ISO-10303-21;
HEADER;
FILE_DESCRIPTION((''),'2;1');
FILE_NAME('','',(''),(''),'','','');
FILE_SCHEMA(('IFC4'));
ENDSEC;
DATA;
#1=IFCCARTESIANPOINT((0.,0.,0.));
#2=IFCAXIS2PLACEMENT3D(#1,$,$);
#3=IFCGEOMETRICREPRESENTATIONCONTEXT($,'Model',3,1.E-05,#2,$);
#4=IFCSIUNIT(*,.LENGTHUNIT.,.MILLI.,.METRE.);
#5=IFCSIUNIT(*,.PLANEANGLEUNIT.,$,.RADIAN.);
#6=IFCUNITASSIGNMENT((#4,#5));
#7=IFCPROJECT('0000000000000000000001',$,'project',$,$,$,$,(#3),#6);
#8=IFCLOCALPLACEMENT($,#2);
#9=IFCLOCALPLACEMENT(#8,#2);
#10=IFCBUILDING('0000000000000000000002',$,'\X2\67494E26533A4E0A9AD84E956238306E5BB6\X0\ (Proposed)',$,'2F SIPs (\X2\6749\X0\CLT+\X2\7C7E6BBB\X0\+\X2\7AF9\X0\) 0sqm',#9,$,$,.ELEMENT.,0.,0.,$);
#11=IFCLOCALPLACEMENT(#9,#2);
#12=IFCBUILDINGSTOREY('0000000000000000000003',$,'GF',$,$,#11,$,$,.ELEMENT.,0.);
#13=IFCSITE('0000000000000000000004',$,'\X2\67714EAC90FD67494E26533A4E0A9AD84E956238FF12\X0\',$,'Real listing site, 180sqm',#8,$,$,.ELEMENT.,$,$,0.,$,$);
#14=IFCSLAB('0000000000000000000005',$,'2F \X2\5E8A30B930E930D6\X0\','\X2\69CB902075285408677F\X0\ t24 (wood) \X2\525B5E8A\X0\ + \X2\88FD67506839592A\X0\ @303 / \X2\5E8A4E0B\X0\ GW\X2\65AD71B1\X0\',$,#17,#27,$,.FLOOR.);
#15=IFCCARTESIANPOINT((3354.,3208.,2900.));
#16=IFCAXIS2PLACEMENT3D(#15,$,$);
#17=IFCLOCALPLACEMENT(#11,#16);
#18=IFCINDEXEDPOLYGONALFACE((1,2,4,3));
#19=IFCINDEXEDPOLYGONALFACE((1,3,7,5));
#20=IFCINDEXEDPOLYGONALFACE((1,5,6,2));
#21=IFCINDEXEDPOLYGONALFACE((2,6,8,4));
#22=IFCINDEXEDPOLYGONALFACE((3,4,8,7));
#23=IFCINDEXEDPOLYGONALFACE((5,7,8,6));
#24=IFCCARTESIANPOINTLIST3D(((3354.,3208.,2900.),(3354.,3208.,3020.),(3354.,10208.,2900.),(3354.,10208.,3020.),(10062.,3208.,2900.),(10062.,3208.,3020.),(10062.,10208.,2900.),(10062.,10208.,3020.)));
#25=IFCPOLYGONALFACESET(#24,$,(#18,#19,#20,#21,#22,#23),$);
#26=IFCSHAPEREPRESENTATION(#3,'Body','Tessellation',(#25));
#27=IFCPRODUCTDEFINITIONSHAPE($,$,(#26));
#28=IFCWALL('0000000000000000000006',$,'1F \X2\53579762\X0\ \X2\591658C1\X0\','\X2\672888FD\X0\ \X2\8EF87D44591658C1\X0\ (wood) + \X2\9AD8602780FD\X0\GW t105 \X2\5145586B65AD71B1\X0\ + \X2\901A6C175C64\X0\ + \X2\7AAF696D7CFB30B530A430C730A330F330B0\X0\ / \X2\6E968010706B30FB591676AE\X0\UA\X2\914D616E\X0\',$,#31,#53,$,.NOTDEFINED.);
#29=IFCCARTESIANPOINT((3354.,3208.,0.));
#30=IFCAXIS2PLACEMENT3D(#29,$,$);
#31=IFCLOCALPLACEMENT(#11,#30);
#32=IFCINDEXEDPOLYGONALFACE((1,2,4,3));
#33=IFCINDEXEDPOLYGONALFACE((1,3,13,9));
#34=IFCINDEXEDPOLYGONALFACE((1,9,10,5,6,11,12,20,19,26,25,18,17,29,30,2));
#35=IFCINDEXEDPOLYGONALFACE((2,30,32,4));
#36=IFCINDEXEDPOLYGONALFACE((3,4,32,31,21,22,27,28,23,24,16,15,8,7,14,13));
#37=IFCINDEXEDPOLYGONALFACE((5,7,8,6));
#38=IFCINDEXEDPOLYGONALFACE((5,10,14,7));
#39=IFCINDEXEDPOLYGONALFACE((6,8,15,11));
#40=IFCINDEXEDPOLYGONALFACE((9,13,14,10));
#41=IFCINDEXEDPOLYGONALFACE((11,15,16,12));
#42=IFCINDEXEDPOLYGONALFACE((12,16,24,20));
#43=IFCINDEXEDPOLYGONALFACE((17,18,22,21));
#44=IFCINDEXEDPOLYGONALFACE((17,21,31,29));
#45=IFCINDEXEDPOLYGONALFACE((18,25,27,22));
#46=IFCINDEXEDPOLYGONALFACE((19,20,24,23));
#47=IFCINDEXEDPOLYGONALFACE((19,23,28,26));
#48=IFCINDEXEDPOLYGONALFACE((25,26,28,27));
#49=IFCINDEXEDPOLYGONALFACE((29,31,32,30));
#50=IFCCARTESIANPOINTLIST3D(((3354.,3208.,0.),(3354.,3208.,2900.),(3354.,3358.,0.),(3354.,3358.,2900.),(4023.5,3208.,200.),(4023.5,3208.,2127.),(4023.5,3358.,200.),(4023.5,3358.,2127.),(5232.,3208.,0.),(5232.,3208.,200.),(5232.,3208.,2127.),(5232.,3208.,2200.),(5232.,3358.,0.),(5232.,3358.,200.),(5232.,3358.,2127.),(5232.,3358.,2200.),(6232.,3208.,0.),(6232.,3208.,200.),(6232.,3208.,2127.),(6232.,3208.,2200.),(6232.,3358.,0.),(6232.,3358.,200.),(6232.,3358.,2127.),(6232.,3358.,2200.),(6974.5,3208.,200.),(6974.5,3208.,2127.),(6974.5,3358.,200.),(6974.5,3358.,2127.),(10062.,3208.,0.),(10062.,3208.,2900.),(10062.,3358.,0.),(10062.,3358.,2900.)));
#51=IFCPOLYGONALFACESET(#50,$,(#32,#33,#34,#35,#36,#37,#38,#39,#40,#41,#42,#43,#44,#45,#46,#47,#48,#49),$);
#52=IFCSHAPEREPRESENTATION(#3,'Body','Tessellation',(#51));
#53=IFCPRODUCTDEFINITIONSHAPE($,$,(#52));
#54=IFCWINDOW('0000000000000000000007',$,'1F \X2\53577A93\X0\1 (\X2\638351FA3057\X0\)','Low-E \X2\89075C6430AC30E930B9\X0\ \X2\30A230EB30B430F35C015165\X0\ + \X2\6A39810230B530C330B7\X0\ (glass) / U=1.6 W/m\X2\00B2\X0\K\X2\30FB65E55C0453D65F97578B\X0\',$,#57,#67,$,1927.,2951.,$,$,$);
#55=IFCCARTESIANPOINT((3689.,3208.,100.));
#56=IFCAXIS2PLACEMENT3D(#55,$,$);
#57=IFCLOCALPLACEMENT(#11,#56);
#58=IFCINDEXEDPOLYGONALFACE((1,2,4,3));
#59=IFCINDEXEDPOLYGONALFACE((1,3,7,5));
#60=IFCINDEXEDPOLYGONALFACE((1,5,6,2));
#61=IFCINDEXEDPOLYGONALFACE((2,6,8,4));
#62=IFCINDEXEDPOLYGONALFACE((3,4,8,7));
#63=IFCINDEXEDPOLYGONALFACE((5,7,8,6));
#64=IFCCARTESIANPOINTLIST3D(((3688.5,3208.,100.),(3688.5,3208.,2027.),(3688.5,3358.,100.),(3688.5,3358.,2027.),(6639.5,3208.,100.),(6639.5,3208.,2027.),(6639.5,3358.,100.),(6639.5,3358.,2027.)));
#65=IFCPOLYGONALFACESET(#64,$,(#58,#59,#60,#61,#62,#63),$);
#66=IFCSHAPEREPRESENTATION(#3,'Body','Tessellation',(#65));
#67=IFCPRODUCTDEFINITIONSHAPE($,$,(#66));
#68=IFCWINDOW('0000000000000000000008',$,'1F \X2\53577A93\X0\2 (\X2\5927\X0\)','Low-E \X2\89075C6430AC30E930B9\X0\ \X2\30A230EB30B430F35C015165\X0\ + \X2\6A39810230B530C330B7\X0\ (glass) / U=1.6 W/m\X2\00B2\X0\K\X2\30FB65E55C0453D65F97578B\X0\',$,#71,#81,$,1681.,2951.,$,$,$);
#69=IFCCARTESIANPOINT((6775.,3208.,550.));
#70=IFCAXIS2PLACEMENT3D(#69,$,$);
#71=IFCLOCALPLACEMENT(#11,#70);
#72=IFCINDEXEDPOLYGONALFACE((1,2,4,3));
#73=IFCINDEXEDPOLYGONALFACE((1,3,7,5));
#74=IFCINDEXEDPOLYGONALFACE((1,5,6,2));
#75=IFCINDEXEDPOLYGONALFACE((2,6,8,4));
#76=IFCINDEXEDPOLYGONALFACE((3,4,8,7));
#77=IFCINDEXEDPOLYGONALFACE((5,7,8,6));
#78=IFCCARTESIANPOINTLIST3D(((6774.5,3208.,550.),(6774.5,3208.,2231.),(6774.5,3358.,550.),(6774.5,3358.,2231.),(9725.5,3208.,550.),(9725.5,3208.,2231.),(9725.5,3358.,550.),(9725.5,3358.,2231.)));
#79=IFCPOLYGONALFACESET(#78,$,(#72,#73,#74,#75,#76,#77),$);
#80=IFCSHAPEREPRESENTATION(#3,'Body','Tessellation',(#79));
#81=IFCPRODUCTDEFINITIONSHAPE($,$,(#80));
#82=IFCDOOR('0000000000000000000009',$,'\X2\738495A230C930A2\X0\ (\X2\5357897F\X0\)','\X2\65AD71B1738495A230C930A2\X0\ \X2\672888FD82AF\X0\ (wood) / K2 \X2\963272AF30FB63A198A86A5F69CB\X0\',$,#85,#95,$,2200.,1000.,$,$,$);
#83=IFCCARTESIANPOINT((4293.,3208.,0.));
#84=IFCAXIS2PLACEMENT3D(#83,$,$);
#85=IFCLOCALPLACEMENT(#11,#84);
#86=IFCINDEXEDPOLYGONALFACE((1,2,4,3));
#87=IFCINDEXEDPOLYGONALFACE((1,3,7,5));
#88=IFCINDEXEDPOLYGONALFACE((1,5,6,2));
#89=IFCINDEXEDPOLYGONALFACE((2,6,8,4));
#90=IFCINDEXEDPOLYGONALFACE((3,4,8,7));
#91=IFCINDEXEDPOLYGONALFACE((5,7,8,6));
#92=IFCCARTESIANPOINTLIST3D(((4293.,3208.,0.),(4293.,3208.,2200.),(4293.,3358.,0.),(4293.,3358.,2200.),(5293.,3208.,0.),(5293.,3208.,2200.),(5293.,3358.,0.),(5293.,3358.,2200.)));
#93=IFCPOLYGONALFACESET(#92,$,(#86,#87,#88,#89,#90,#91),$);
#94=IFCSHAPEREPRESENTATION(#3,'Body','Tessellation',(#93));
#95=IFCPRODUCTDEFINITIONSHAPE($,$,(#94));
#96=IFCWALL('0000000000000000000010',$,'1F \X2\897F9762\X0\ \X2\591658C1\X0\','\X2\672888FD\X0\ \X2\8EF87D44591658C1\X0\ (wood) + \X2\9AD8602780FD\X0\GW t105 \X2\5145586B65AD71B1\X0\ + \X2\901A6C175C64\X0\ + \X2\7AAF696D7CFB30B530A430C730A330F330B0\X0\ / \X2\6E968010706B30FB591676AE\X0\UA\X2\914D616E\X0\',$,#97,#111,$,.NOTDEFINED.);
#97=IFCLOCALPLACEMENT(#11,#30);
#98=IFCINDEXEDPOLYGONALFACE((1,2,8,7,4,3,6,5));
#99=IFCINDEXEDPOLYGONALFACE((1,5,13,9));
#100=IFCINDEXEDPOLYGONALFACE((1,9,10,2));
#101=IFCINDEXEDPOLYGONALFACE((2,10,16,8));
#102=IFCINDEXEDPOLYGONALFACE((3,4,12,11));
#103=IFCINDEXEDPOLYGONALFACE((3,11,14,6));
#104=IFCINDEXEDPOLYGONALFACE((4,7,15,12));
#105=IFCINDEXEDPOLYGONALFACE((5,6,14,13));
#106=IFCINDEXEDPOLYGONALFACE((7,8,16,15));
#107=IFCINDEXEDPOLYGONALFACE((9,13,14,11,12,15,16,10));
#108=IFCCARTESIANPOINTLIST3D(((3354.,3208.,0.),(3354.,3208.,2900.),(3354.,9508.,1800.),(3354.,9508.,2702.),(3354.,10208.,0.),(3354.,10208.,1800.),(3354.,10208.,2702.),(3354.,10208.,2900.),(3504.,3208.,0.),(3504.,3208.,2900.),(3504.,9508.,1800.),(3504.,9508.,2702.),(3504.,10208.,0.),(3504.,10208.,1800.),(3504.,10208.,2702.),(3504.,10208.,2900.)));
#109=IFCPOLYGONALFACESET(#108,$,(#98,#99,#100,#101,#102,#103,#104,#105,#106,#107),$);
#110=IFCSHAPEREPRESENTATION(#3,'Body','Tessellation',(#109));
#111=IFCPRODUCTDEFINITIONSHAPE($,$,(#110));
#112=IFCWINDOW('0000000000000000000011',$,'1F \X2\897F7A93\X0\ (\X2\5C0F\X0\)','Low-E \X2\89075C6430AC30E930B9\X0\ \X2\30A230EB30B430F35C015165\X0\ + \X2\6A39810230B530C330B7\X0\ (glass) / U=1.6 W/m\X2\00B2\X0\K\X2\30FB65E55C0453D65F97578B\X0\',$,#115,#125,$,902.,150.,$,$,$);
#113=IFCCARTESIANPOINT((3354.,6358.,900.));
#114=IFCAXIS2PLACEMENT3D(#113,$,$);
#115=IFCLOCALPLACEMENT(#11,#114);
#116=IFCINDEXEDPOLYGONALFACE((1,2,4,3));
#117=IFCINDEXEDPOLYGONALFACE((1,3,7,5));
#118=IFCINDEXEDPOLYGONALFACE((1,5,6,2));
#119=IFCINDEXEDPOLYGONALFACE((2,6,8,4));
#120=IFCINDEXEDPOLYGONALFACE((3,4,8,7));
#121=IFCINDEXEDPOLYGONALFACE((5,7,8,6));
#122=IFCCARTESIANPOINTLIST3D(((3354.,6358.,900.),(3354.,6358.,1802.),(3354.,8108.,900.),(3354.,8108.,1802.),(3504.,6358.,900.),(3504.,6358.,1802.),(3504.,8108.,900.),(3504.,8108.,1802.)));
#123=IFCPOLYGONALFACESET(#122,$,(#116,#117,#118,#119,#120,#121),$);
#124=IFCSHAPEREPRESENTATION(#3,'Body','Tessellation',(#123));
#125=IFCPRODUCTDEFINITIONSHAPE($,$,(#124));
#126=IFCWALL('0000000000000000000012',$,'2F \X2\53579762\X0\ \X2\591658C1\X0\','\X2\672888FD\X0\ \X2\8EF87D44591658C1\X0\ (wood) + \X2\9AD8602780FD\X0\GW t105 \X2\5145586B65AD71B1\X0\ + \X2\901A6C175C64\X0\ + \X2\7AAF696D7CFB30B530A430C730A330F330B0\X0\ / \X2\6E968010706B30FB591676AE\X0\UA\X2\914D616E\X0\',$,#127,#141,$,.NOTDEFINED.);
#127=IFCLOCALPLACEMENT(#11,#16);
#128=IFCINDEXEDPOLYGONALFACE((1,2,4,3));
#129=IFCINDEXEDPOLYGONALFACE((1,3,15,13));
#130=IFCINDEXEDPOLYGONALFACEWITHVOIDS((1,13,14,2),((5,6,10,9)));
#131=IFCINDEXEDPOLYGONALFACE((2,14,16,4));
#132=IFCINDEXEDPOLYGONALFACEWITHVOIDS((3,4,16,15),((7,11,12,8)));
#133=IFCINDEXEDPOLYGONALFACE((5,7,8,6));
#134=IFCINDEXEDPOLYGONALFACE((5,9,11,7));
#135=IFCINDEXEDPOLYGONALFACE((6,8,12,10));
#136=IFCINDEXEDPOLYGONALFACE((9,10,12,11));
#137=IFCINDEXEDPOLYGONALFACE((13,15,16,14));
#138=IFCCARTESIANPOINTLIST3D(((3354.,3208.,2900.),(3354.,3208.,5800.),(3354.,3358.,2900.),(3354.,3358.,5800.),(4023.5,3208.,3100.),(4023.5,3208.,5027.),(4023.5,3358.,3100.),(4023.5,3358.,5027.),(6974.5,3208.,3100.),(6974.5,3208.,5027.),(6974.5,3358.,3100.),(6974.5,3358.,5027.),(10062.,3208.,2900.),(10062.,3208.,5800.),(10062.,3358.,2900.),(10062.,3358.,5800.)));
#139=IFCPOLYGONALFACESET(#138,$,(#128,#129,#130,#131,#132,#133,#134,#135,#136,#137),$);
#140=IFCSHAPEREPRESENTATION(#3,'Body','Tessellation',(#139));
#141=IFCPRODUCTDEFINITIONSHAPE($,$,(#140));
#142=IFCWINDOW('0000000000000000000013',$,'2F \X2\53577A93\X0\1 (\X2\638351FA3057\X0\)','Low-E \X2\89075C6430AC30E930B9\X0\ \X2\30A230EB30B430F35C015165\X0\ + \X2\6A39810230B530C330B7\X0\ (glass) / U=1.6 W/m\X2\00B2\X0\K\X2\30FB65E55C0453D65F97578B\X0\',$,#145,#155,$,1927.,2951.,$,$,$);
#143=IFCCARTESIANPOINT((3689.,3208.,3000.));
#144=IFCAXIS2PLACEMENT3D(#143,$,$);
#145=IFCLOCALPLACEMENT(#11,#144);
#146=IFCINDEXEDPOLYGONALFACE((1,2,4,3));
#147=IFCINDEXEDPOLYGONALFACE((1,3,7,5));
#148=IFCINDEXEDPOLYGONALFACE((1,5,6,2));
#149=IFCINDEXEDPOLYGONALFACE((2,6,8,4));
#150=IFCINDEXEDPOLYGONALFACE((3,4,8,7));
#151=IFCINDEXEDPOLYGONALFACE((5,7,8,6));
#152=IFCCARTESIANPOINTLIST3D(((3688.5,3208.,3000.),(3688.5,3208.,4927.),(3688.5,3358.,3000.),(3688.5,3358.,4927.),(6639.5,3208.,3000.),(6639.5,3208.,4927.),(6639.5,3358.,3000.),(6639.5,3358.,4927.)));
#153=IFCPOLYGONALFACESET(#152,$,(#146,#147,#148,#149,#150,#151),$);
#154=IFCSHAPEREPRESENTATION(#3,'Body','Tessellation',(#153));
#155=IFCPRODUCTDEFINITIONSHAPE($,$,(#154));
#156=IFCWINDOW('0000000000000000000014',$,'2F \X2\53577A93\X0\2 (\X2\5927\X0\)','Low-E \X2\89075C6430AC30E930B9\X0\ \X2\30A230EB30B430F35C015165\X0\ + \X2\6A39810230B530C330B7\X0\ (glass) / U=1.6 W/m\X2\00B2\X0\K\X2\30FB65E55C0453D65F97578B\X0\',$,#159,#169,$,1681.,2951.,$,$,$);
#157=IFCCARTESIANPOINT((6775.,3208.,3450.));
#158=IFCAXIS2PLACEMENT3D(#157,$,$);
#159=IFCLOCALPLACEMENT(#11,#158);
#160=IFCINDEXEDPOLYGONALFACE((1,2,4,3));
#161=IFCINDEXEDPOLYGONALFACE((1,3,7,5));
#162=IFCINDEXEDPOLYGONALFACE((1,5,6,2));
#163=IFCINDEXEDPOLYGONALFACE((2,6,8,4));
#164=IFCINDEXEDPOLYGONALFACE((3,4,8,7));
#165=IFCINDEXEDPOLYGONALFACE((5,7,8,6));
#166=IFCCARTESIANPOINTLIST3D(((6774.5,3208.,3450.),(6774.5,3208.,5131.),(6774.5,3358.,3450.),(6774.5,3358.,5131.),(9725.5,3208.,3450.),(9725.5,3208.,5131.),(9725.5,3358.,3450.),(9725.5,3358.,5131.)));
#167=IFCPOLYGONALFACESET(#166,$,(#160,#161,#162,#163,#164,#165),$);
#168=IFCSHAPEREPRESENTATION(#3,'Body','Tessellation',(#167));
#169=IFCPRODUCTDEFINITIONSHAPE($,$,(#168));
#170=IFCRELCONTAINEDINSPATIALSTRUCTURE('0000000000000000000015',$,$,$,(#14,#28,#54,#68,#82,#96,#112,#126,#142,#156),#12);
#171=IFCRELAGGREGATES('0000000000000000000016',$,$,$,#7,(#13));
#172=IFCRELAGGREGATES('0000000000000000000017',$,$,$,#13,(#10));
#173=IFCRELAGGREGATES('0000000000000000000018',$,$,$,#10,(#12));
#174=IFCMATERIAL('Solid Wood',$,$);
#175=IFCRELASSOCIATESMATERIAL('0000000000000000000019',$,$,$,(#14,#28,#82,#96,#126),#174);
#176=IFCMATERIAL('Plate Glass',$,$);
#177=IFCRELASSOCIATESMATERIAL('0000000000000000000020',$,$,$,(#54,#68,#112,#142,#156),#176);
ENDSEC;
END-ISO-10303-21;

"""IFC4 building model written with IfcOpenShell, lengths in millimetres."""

from ifc_helpers import new_model, si_unit, frame, frame_2d, origin, place, context, project, spatial, rectangle, extrude, material, element, fill, save


model = new_model("IFC4")

# Units and contexts
model_context = context("Model", 3, precision=1e-05, world=origin())
ifc_project = project(units=[si_unit("LENGTHUNIT", "METRE", prefix="MILLI"), si_unit("PLANEANGLEUNIT", "RADIAN")], contexts=[model_context])

# Site, building, storey
site_placement = place(None, origin())
site = spatial("IfcSite", under=ifc_project, at=site_placement, Name="東京都杉並区上高井戸２", ObjectType="Real listing site, 180sqm", CompositionType="ELEMENT", RefElevation=0.0)
building_placement = place(site_placement, origin())
building = spatial("IfcBuilding", under=site, at=building_placement, Name="杉並区上高井戸の家 (Proposed)", ObjectType="2F SIPs (杉CLT+籾殻+竹) 0sqm", CompositionType="ELEMENT", ElevationOfRefHeight=0.0, ElevationOfTerrain=0.0)
storey_placement = place(building_placement, origin())
storey = spatial("IfcBuildingStorey", under=building, at=storey_placement, Name="GF", CompositionType="ELEMENT", Elevation=0.0)

# Slab
ifc_material_1 = material(Name="Solid Wood")
slab_1_placement = place(storey_placement, frame((3354.0, 3208.0, 2900.0)))
element("IfcSlab", 1, at=slab_1_placement, inside=storey, material=ifc_material_1, Name="2F 床スラブ", Description="構造用合板 t24 (wood) 剛床 + 製材根太 @303 / 床下 GW断熱", PredefinedType="FLOOR", context=model_context, shape_type="SweptSolid", body=[
    extrude(rectangle(XDim=6708.0, YDim=7000.0, at=frame_2d((3354.0, 3500.0))), frame((3354.0, 3208.0, 2900.0)), (0.0, 0.0, 1.0), 120.0),
])

# Wall, openings, windows, door
wall_1_placement = place(storey_placement, frame((3354.0, 3208.0, 0.0)))
wall_1 = element("IfcWall", 2, at=wall_1_placement, inside=storey, material=ifc_material_1, Name="1F 南面 外壁", Description="木製 軸組外壁 (wood) + 高性能GW t105 充填断熱 + 通気層 + 窯業系サイディング / 準耐火・外皮UA配慮", PredefinedType="NOTDEFINED", context=model_context, shape_type="SweptSolid", body=[
    extrude(rectangle(XDim=6708.0, YDim=150.0, at=frame_2d((3354.0, 75.0))), frame((3354.0, 3208.0, 0.0)), (0.0, 0.0, 1.0), 2900.0),
])
opening_1_placement = place(storey_placement, frame((3689.0, 3208.0, 100.0)))
opening_1 = element("IfcOpeningElement", 3, at=opening_1_placement, cuts=wall_1, PredefinedType="NOTDEFINED", context=model_context, shape_type="SweptSolid", body=[
    extrude(rectangle(XDim=2951.0, YDim=150.0, at=frame_2d((1475.0, 75.0))), frame((3689.0, 3208.0, 100.0)), (0.0, 0.0, 1.0), 1927.0),
])
opening_2_placement = place(storey_placement, frame((6775.0, 3208.0, 550.0)))
opening_2 = element("IfcOpeningElement", 4, at=opening_2_placement, cuts=wall_1, PredefinedType="NOTDEFINED", context=model_context, shape_type="SweptSolid", body=[
    extrude(rectangle(XDim=2951.0, YDim=150.0, at=frame_2d((1475.0, 75.0))), frame((6775.0, 3208.0, 550.0)), (0.0, 0.0, 1.0), 1681.0),
])
opening_3_placement = place(storey_placement, frame((4293.0, 3208.0, 0.0)))
opening_3 = element("IfcOpeningElement", 5, at=opening_3_placement, cuts=wall_1, PredefinedType="NOTDEFINED", context=model_context, shape_type="SweptSolid", body=[
    extrude(rectangle(XDim=1000.0, YDim=150.0, at=frame_2d((500.0, 75.0))), frame((4293.0, 3208.0, 0.0)), (0.0, 0.0, 1.0), 2200.0),
])
ifc_material_2 = material(Name="Plate Glass")
window_1_placement = place(storey_placement, frame((3689.0, 3208.0, 100.0)))
window_1 = element("IfcWindow", 6, at=window_1_placement, inside=storey, material=ifc_material_2, Name="1F 南窓1 (掃出し)", Description="Low-E 複層ガラス アルゴン封入 + 樹脂サッシ (glass) / U=1.6 W/m²K・日射取得型", OverallHeight=1927.0, OverallWidth=2951.0, context=model_context, shape_type="SweptSolid", body=[
    extrude(rectangle(XDim=2951.0, YDim=150.0, at=frame_2d((1475.0, 75.0))), frame((3689.0, 3208.0, 100.0)), (0.0, 0.0, 1.0), 1927.0),
])
fill(opening_1, window_1)
window_2_placement = place(storey_placement, frame((6775.0, 3208.0, 550.0)))
window_2 = element("IfcWindow", 7, at=window_2_placement, inside=storey, material=ifc_material_2, Name="1F 南窓2 (大)", Description="Low-E 複層ガラス アルゴン封入 + 樹脂サッシ (glass) / U=1.6 W/m²K・日射取得型", OverallHeight=1681.0, OverallWidth=2951.0, context=model_context, shape_type="SweptSolid", body=[
    extrude(rectangle(XDim=2951.0, YDim=150.0, at=frame_2d((1475.0, 75.0))), frame((6775.0, 3208.0, 550.0)), (0.0, 0.0, 1.0), 1681.0),
])
fill(opening_2, window_2)
door_placement = place(storey_placement, frame((4293.0, 3208.0, 0.0)))
door = element("IfcDoor", 8, at=door_placement, inside=storey, material=ifc_material_1, Name="玄関ドア (南西)", Description="断熱玄関ドア 木製芯 (wood) / K2 防犯・採風機構", OverallHeight=2200.0, OverallWidth=1000.0, context=model_context, shape_type="SweptSolid", body=[
    extrude(rectangle(XDim=1000.0, YDim=150.0, at=frame_2d((500.0, 75.0))), frame((4293.0, 3208.0, 0.0)), (0.0, 0.0, 1.0), 2200.0),
])
fill(opening_3, door)

# Wall, opening, window
wall_2_placement = place(storey_placement, frame((3354.0, 3208.0, 0.0)))
wall_2 = element("IfcWall", 9, at=wall_2_placement, inside=storey, material=ifc_material_1, Name="1F 西面 外壁", Description="木製 軸組外壁 (wood) + 高性能GW t105 充填断熱 + 通気層 + 窯業系サイディング / 準耐火・外皮UA配慮", PredefinedType="NOTDEFINED", context=model_context, shape_type="SweptSolid", body=[
    extrude(rectangle(XDim=150.0, YDim=7000.0, at=frame_2d((75.0, 3500.0))), frame((3354.0, 3208.0, 0.0)), (0.0, 0.0, 1.0), 2900.0),
])
opening_4_placement = place(storey_placement, frame((3354.0, 6358.0, 900.0)))
opening_4 = element("IfcOpeningElement", 10, at=opening_4_placement, cuts=wall_2, PredefinedType="NOTDEFINED", context=model_context, shape_type="SweptSolid", body=[
    extrude(rectangle(XDim=150.0, YDim=1750.0, at=frame_2d((75.0, 875.0))), frame((3354.0, 6358.0, 900.0)), (0.0, 0.0, 1.0), 902.0),
])
window_3_placement = place(storey_placement, frame((3354.0, 6358.0, 900.0)))
window_3 = element("IfcWindow", 11, at=window_3_placement, inside=storey, material=ifc_material_2, Name="1F 西窓 (小)", Description="Low-E 複層ガラス アルゴン封入 + 樹脂サッシ (glass) / U=1.6 W/m²K・日射取得型", OverallHeight=902.0, OverallWidth=150.0, context=model_context, shape_type="SweptSolid", body=[
    extrude(rectangle(XDim=150.0, YDim=1750.0, at=frame_2d((75.0, 875.0))), frame((3354.0, 6358.0, 900.0)), (0.0, 0.0, 1.0), 902.0),
])
fill(opening_4, window_3)

# Wall, openings, windows
wall_3_placement = place(storey_placement, frame((3354.0, 3208.0, 2900.0)))
wall_3 = element("IfcWall", 12, at=wall_3_placement, inside=storey, material=ifc_material_1, Name="2F 南面 外壁", Description="木製 軸組外壁 (wood) + 高性能GW t105 充填断熱 + 通気層 + 窯業系サイディング / 準耐火・外皮UA配慮", PredefinedType="NOTDEFINED", context=model_context, shape_type="SweptSolid", body=[
    extrude(rectangle(XDim=6708.0, YDim=150.0, at=frame_2d((3354.0, 75.0))), frame((3354.0, 3208.0, 2900.0)), (0.0, 0.0, 1.0), 2900.0),
])
opening_5_placement = place(storey_placement, frame((3689.0, 3208.0, 3000.0)))
opening_5 = element("IfcOpeningElement", 13, at=opening_5_placement, cuts=wall_3, PredefinedType="NOTDEFINED", context=model_context, shape_type="SweptSolid", body=[
    extrude(rectangle(XDim=2951.0, YDim=150.0, at=frame_2d((1475.0, 75.0))), frame((3689.0, 3208.0, 3000.0)), (0.0, 0.0, 1.0), 1927.0),
])
opening_6_placement = place(storey_placement, frame((6775.0, 3208.0, 3450.0)))
opening_6 = element("IfcOpeningElement", 14, at=opening_6_placement, cuts=wall_3, PredefinedType="NOTDEFINED", context=model_context, shape_type="SweptSolid", body=[
    extrude(rectangle(XDim=2951.0, YDim=150.0, at=frame_2d((1475.0, 75.0))), frame((6775.0, 3208.0, 3450.0)), (0.0, 0.0, 1.0), 1681.0),
])
window_4_placement = place(storey_placement, frame((3689.0, 3208.0, 3000.0)))
window_4 = element("IfcWindow", 15, at=window_4_placement, inside=storey, material=ifc_material_2, Name="2F 南窓1 (掃出し)", Description="Low-E 複層ガラス アルゴン封入 + 樹脂サッシ (glass) / U=1.6 W/m²K・日射取得型", OverallHeight=1927.0, OverallWidth=2951.0, context=model_context, shape_type="SweptSolid", body=[
    extrude(rectangle(XDim=2951.0, YDim=150.0, at=frame_2d((1475.0, 75.0))), frame((3689.0, 3208.0, 3000.0)), (0.0, 0.0, 1.0), 1927.0),
])
fill(opening_5, window_4)
window_5_placement = place(storey_placement, frame((6775.0, 3208.0, 3450.0)))
window_5 = element("IfcWindow", 16, at=window_5_placement, inside=storey, material=ifc_material_2, Name="2F 南窓2 (大)", Description="Low-E 複層ガラス アルゴン封入 + 樹脂サッシ (glass) / U=1.6 W/m²K・日射取得型", OverallHeight=1681.0, OverallWidth=2951.0, context=model_context, shape_type="SweptSolid", body=[
    extrude(rectangle(XDim=2951.0, YDim=150.0, at=frame_2d((1475.0, 75.0))), frame((6775.0, 3208.0, 3450.0)), (0.0, 0.0, 1.0), 1681.0),
])
fill(opening_6, window_5)

save(model, "model.ifc")
